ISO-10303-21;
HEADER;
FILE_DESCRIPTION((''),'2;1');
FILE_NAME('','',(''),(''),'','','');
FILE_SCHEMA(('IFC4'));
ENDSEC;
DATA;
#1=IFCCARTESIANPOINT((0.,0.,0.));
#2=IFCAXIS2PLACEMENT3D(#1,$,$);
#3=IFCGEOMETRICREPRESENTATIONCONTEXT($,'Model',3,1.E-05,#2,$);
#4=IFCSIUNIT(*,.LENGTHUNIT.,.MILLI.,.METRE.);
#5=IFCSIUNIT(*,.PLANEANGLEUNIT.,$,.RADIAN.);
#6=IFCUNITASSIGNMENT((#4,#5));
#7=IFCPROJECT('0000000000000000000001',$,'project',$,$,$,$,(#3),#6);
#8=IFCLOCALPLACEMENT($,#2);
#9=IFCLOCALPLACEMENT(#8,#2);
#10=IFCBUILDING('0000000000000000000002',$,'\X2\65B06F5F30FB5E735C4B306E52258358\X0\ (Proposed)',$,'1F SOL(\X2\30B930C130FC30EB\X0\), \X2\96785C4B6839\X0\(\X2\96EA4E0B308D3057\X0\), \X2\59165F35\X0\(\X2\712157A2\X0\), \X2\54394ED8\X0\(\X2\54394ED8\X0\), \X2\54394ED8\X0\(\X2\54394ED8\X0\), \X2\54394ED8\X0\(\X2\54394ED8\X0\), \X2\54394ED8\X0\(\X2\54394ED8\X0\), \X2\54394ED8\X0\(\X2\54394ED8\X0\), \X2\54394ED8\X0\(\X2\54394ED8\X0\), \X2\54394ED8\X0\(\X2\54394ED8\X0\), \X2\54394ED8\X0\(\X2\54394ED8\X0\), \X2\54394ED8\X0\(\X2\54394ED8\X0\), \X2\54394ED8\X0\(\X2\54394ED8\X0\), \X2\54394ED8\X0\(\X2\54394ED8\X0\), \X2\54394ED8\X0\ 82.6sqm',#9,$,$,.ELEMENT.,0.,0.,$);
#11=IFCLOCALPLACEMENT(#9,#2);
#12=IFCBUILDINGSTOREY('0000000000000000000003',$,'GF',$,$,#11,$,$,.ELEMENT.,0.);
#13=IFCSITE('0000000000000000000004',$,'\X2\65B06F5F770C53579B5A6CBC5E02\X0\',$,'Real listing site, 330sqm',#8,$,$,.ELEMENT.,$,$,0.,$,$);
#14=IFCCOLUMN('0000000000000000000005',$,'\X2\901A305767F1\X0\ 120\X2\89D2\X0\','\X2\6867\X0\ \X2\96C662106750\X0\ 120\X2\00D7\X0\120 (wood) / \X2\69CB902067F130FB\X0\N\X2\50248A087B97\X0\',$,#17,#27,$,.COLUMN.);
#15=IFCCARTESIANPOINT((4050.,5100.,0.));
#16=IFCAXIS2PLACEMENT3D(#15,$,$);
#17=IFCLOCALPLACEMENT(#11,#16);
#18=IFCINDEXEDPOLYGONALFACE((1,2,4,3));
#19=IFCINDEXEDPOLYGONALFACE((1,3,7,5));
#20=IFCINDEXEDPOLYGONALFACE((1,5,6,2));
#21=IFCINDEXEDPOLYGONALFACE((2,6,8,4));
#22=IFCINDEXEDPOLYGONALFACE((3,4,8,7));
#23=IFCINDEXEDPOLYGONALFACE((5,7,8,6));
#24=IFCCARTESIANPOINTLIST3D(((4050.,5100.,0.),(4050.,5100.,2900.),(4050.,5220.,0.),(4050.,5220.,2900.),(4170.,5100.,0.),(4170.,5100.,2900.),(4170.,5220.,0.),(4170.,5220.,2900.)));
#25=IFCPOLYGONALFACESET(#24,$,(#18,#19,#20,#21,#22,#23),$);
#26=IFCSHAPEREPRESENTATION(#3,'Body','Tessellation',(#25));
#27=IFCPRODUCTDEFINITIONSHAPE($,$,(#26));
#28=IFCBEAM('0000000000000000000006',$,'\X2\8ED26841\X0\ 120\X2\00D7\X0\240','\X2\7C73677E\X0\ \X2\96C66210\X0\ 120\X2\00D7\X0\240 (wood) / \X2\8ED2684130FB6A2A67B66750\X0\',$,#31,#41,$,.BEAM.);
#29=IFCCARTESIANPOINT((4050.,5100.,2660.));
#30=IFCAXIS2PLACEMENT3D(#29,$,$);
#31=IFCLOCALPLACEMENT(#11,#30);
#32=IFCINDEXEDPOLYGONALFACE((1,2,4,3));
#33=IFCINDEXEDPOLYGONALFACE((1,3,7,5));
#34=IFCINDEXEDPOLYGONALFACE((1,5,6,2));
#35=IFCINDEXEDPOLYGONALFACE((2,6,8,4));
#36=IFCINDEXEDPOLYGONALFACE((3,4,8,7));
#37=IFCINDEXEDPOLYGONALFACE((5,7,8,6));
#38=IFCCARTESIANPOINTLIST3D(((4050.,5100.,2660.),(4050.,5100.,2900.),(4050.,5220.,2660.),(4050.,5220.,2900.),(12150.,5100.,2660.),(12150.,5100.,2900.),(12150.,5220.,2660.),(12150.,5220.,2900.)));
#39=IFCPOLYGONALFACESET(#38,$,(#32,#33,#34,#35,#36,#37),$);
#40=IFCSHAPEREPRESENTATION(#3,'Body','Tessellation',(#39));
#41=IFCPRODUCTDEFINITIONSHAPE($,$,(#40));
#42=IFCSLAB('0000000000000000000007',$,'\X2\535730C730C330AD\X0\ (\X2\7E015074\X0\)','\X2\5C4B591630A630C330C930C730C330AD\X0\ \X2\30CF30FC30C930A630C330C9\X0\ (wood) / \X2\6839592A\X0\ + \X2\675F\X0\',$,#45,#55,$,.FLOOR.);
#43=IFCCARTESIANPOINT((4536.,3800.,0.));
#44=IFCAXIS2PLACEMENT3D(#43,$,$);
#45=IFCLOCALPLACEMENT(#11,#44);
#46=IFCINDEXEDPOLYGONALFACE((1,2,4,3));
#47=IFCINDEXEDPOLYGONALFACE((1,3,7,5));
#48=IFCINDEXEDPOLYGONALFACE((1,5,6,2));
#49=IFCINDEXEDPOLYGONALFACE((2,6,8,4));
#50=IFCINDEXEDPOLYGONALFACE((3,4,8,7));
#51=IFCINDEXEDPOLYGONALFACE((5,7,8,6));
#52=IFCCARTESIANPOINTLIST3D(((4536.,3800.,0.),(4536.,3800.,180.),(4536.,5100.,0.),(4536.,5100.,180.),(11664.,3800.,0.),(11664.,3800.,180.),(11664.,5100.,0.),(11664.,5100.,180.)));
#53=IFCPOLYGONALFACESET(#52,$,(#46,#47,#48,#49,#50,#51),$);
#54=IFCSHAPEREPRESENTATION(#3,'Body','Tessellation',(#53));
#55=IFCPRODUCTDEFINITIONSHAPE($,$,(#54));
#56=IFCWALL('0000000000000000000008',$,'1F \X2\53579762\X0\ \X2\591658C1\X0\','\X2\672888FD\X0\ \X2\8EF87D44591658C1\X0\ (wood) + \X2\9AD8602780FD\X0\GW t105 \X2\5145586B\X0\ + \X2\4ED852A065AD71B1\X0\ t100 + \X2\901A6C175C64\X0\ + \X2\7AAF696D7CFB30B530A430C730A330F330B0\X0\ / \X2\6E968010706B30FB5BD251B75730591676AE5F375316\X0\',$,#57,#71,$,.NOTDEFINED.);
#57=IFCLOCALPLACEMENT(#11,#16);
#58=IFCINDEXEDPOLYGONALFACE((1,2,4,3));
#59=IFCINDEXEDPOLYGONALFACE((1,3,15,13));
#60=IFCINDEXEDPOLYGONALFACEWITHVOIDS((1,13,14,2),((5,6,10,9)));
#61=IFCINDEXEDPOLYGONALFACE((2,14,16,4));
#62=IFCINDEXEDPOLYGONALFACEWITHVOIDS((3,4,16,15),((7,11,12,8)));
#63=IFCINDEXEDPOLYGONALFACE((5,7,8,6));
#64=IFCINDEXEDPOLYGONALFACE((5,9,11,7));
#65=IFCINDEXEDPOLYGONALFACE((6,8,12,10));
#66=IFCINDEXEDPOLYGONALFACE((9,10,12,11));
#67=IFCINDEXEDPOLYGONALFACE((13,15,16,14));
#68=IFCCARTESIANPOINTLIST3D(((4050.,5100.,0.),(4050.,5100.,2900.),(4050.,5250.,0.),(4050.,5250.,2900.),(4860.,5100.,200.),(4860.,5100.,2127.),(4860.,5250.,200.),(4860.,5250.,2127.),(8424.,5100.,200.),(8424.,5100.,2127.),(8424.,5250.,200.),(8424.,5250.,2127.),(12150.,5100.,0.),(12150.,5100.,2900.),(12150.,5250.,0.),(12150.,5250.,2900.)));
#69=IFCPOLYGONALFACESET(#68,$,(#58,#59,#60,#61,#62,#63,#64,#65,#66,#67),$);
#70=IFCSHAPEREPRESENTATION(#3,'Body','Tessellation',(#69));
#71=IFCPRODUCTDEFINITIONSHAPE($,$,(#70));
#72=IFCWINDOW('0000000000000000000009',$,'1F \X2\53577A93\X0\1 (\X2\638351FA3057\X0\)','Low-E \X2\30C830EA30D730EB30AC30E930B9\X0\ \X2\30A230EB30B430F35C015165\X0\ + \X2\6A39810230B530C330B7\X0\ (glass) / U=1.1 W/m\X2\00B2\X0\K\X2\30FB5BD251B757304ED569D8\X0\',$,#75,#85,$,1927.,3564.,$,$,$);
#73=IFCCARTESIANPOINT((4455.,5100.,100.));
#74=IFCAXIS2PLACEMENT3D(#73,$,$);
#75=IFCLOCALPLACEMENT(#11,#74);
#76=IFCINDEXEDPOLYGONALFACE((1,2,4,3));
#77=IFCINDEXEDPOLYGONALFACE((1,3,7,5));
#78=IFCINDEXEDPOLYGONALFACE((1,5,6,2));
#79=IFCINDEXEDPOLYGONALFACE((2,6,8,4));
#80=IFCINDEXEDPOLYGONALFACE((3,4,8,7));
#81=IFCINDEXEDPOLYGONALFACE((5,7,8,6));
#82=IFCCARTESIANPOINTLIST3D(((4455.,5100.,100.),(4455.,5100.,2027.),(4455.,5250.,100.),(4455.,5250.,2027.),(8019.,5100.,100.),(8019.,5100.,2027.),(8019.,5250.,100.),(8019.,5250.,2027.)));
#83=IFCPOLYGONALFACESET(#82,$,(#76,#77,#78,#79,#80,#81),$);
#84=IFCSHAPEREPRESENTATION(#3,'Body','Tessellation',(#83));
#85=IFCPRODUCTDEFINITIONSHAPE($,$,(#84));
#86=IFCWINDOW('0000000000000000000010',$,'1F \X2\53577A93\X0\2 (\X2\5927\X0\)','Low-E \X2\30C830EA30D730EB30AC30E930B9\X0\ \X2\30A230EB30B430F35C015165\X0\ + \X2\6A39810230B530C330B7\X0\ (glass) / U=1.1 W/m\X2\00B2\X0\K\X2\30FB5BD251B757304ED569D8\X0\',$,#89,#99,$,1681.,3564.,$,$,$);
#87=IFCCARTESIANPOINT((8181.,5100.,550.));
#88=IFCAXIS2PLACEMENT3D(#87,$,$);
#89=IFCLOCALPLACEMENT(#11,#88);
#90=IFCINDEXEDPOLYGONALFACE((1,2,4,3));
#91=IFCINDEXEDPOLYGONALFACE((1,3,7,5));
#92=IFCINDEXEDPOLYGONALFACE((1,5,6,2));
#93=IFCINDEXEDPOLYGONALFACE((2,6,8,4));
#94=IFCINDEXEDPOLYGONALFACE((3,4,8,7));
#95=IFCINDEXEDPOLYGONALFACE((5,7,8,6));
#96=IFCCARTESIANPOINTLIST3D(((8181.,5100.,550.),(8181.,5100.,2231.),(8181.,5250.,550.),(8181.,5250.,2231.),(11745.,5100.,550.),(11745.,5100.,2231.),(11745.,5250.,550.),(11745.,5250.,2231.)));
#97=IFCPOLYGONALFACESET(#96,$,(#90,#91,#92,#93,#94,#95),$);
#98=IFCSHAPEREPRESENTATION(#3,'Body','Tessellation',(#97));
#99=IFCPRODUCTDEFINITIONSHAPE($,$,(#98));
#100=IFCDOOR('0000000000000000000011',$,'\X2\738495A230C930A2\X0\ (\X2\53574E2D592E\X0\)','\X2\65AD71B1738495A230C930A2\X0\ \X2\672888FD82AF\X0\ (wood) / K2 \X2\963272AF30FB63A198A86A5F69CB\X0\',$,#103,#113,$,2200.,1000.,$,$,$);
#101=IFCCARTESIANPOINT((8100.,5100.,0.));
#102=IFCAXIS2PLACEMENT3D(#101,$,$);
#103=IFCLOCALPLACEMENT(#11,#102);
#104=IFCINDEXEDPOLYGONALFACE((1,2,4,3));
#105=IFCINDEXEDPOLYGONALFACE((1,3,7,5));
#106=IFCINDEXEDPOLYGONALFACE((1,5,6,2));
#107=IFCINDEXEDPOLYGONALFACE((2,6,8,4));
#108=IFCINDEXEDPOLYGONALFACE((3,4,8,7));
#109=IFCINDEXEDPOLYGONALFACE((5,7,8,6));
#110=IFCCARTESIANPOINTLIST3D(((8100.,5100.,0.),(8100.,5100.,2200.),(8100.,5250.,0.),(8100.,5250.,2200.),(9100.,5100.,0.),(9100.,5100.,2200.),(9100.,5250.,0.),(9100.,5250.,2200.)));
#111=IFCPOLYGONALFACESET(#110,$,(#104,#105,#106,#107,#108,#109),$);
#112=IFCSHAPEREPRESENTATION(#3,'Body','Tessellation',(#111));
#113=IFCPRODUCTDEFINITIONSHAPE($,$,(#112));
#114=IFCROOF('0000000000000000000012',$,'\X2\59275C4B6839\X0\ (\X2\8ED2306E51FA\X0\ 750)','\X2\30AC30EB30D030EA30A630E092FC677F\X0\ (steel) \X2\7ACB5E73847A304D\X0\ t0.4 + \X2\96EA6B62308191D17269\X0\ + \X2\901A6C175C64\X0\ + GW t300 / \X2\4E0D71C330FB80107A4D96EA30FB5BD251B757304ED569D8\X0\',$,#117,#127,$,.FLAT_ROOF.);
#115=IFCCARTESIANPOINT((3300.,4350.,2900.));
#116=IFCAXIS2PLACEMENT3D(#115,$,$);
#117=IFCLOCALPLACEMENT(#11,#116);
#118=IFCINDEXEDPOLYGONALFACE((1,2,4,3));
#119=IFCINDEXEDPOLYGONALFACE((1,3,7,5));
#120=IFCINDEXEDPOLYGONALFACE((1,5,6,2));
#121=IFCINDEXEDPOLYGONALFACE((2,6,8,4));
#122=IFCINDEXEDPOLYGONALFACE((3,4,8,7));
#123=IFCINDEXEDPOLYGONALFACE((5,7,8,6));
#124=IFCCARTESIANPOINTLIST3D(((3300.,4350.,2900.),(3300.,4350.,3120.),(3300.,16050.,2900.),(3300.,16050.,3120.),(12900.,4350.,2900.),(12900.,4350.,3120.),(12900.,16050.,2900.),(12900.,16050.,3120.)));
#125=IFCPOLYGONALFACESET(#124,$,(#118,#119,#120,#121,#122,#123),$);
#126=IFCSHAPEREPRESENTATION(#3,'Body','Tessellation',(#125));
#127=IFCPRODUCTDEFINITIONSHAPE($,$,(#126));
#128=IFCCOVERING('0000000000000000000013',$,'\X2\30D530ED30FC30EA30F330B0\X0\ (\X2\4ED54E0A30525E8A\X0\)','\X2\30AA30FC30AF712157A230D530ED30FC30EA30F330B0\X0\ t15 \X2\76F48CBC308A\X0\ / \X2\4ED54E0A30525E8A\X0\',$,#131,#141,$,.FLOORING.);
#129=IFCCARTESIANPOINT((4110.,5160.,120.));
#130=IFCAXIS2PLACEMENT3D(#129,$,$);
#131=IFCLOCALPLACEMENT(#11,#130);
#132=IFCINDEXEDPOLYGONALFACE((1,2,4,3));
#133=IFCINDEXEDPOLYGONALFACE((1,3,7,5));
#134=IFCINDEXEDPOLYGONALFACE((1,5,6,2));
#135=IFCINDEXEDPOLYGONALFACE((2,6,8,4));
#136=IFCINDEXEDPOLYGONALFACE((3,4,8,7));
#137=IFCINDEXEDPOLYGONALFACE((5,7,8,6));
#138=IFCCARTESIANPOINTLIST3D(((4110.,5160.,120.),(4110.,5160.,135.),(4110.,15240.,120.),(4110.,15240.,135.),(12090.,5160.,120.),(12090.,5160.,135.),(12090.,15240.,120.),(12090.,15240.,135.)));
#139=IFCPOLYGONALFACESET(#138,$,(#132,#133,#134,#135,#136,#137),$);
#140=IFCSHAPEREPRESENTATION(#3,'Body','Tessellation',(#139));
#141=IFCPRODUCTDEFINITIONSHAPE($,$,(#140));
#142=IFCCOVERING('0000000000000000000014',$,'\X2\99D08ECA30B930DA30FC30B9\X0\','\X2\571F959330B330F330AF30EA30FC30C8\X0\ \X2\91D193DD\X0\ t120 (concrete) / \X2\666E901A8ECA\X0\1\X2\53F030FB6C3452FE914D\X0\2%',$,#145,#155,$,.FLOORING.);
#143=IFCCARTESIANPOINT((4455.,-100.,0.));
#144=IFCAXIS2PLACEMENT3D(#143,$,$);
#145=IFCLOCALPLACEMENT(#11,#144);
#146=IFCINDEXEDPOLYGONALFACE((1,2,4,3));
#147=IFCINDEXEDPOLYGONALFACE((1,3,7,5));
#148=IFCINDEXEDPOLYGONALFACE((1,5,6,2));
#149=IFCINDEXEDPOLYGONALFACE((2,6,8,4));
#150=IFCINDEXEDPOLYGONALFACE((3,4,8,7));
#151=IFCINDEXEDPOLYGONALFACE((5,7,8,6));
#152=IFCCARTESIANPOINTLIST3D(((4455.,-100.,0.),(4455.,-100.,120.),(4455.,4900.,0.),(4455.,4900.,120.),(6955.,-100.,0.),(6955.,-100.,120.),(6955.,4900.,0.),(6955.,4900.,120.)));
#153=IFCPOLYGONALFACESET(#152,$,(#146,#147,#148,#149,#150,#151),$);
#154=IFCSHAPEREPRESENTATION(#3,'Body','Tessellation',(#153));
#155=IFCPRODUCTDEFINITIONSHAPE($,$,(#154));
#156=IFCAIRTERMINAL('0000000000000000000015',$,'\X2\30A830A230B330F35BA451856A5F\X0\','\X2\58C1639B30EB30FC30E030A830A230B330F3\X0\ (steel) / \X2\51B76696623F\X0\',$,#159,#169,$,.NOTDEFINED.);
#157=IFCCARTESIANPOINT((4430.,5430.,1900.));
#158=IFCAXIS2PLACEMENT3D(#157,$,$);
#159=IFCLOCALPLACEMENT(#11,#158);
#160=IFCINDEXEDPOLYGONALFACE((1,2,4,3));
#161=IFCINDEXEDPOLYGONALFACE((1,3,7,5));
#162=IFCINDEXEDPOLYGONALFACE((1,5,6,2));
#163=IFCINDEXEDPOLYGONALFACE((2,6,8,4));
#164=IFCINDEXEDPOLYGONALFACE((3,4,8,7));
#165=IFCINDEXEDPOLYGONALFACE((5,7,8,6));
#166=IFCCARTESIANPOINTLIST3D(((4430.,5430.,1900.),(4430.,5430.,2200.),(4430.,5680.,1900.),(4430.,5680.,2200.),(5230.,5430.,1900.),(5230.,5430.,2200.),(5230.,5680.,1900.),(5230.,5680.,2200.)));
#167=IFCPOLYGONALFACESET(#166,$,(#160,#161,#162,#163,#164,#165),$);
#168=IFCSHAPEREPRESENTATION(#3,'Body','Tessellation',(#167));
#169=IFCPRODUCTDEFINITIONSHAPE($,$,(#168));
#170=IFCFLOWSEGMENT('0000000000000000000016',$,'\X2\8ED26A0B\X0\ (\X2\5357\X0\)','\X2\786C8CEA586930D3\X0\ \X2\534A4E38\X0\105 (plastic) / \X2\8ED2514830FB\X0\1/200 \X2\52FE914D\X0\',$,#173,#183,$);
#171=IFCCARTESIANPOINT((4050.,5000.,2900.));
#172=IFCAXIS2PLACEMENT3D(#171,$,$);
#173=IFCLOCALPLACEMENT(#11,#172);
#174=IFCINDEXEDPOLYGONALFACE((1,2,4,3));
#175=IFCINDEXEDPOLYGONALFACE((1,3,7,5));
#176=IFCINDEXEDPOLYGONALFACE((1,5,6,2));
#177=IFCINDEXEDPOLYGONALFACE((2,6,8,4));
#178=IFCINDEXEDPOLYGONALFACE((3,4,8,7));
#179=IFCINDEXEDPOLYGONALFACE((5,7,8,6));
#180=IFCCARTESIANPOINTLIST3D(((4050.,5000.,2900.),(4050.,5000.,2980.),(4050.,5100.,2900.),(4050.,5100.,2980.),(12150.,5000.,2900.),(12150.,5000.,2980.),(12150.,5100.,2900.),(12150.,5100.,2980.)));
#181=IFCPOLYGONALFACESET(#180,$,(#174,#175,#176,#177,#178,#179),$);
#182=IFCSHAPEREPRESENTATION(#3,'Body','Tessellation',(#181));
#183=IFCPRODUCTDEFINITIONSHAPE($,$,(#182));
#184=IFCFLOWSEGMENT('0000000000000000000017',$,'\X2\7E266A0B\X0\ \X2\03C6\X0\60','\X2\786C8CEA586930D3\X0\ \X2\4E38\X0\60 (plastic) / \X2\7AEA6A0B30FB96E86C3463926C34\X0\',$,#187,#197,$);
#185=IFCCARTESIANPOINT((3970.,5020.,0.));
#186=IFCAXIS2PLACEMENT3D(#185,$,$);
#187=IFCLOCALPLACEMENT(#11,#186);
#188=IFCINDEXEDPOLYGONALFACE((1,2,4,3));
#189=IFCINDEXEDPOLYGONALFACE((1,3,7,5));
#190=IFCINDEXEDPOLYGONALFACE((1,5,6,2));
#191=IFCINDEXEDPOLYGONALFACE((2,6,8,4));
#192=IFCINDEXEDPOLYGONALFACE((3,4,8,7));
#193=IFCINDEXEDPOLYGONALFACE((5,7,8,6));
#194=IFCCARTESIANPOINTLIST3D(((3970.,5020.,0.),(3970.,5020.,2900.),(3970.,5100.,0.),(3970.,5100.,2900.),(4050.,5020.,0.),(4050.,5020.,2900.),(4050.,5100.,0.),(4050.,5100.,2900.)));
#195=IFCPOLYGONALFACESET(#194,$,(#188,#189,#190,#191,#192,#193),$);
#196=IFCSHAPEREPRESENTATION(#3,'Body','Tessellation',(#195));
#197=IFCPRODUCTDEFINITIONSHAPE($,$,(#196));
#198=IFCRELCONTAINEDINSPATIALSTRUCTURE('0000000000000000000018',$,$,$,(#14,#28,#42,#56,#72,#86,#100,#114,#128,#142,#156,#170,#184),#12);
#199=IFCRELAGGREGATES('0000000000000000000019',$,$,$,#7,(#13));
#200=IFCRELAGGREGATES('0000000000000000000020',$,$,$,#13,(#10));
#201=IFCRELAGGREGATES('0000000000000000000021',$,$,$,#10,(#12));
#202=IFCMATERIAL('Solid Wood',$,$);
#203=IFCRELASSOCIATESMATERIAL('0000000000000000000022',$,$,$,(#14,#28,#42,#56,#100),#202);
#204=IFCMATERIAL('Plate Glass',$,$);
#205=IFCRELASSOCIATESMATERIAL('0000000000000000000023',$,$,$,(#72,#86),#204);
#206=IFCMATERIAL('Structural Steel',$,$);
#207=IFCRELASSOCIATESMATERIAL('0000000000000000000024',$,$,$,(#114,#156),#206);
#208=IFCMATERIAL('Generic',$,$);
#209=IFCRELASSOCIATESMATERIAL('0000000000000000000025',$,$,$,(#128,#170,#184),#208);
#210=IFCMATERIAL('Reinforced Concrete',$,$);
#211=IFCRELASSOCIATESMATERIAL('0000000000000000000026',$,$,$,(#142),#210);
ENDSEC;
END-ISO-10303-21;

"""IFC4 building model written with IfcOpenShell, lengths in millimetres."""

from ifc_helpers import new_model, si_unit, frame, frame_2d, origin, place, context, project, spatial, rectangle, extrude, material, element, fill, save


model = new_model("IFC4")

# Units and contexts
model_context = context("Model", 3, precision=1e-05, world=origin())
ifc_project = project(units=[si_unit("LENGTHUNIT", "METRE", prefix="MILLI"), si_unit("PLANEANGLEUNIT", "RADIAN")], contexts=[model_context])

# Site, building, storey
site_placement = place(None, origin())
site = spatial("IfcSite", under=ifc_project, at=site_placement, Name="新潟県南魚沼市", ObjectType="Real listing site, 330sqm", CompositionType="ELEMENT", RefElevation=0.0)
building_placement = place(site_placement, origin())
building = spatial("IfcBuilding", under=site, at=building_placement, Name="新潟・平屋の別荘 (Proposed)", ObjectType="1F SOL(スチール), 陸屋根(雪下ろし), 外張(無垢), 吹付(吹付), 吹付(吹付), 吹付(吹付), 吹付(吹付), 吹付(吹付), 吹付(吹付), 吹付(吹付), 吹付(吹付), 吹付(吹付), 吹付(吹付), 吹付(吹付), 吹付 82.6sqm", CompositionType="ELEMENT", ElevationOfRefHeight=0.0, ElevationOfTerrain=0.0)
storey_placement = place(building_placement, origin())
storey = spatial("IfcBuildingStorey", under=building, at=storey_placement, Name="GF", CompositionType="ELEMENT", Elevation=0.0)

# Column
ifc_material_1 = material(Name="Solid Wood")
column_1_placement = place(storey_placement, frame((4050.0, 5100.0, 0.0)))
element("IfcColumn", 1, at=column_1_placement, inside=storey, material=ifc_material_1, Name="通し柱 120角", Description="桧 集成材 120×120 (wood) / 構造柱・N値計算", PredefinedType="COLUMN", context=model_context, shape_type="SweptSolid", body=[
    extrude(rectangle(XDim=120.0, YDim=120.0, at=frame_2d((60.0, 60.0))), frame((4050.0, 5100.0, 0.0)), (0.0, 0.0, 1.0), 2900.0),
])

# Beam
beam_1_placement = place(storey_placement, frame((4050.0, 5100.0, 2660.0)))
element("IfcBeam", 2, at=beam_1_placement, inside=storey, material=ifc_material_1, Name="軒桁 120×240", Description="米松 集成 120×240 (wood) / 軒桁・横架材", PredefinedType="BEAM", context=model_context, shape_type="SweptSolid", body=[
    extrude(rectangle(XDim=8100.0, YDim=120.0, at=frame_2d((4050.0, 60.0))), frame((4050.0, 5100.0, 2660.0)), (0.0, 0.0, 1.0), 240.0),
])

# Slab
ifc_material_2 = material(Name="Reinforced Concrete")
slab_1_placement = place(storey_placement, frame((4536.0, 3800.0, 0.0)))
element("IfcSlab", 3, at=slab_1_placement, inside=storey, material=ifc_material_1, Name="南デッキ (縁側)", Description="屋外ウッドデッキ ハードウッド (wood) / 根太 + 束", PredefinedType="FLOOR", context=model_context, shape_type="SweptSolid", body=[
    extrude(rectangle(XDim=7128.0, YDim=1300.0, at=frame_2d((3564.0, 650.0))), frame((4536.0, 3800.0, 0.0)), (0.0, 0.0, 1.0), 180.0),
])

# Wall, openings, windows, door
wall_1_placement = place(storey_placement, frame((4050.0, 5100.0, 0.0)))
wall_1 = element("IfcWall", 4, at=wall_1_placement, inside=storey, material=ifc_material_1, Name="1F 南面 外壁", Description="木製 軸組外壁 (wood) + 高性能GW t105 充填 + 付加断熱 t100 + 通気層 + 窯業系サイディング / 準耐火・寒冷地外皮強化", PredefinedType="NOTDEFINED", context=model_context, shape_type="SweptSolid", body=[
    extrude(rectangle(XDim=8100.0, YDim=150.0, at=frame_2d((4050.0, 75.0))), frame((4050.0, 5100.0, 0.0)), (0.0, 0.0, 1.0), 2900.0),
])
opening_1_placement = place(storey_placement, frame((4455.0, 5100.0, 100.0)))
opening_1 = element("IfcOpeningElement", 5, at=opening_1_placement, cuts=wall_1, PredefinedType="NOTDEFINED", context=model_context, shape_type="SweptSolid", body=[
    extrude(rectangle(XDim=3564.0, YDim=150.0, at=frame_2d((1782.0, 75.0))), frame((4455.0, 5100.0, 100.0)), (0.0, 0.0, 1.0), 1927.0),
])
opening_2_placement = place(storey_placement, frame((8181.0, 5100.0, 550.0)))
opening_2 = element("IfcOpeningElement", 6, at=opening_2_placement, cuts=wall_1, PredefinedType="NOTDEFINED", context=model_context, shape_type="SweptSolid", body=[
    extrude(rectangle(XDim=3564.0, YDim=150.0, at=frame_2d((1782.0, 75.0))), frame((8181.0, 5100.0, 550.0)), (0.0, 0.0, 1.0), 1681.0),
])
opening_3_placement = place(storey_placement, frame((8100.0, 5100.0, 0.0)))
opening_3 = element("IfcOpeningElement", 7, at=opening_3_placement, cuts=wall_1, PredefinedType="NOTDEFINED", context=model_context, shape_type="SweptSolid", body=[
    extrude(rectangle(XDim=1000.0, YDim=150.0, at=frame_2d((500.0, 75.0))), frame((8100.0, 5100.0, 0.0)), (0.0, 0.0, 1.0), 2200.0),
])
ifc_material_3 = material(Name="Plate Glass")
window_1_placement = place(storey_placement, frame((4455.0, 5100.0, 100.0)))
window_1 = element("IfcWindow", 8, at=window_1_placement, inside=storey, material=ifc_material_3, Name="1F 南窓1 (掃出し)", Description="Low-E トリプルガラス アルゴン封入 + 樹脂サッシ (glass) / U=1.1 W/m²K・寒冷地仕様", OverallHeight=1927.0, OverallWidth=3564.0, context=model_context, shape_type="SweptSolid", body=[
    extrude(rectangle(XDim=3564.0, YDim=150.0, at=frame_2d((1782.0, 75.0))), frame((4455.0, 5100.0, 100.0)), (0.0, 0.0, 1.0), 1927.0),
])
fill(opening_1, window_1)
window_2_placement = place(storey_placement, frame((8181.0, 5100.0, 550.0)))
window_2 = element("IfcWindow", 9, at=window_2_placement, inside=storey, material=ifc_material_3, Name="1F 南窓2 (大)", Description="Low-E トリプルガラス アルゴン封入 + 樹脂サッシ (glass) / U=1.1 W/m²K・寒冷地仕様", OverallHeight=1681.0, OverallWidth=3564.0, context=model_context, shape_type="SweptSolid", body=[
    extrude(rectangle(XDim=3564.0, YDim=150.0, at=frame_2d((1782.0, 75.0))), frame((8181.0, 5100.0, 550.0)), (0.0, 0.0, 1.0), 1681.0),
])
fill(opening_2, window_2)
door_placement = place(storey_placement, frame((8100.0, 5100.0, 0.0)))
door = element("IfcDoor", 10, at=door_placement, inside=storey, material=ifc_material_1, Name="玄関ドア (南中央)", Description="断熱玄関ドア 木製芯 (wood) / K2 防犯・採風機構", OverallHeight=2200.0, OverallWidth=1000.0, context=model_context, shape_type="SweptSolid", body=[
    extrude(rectangle(XDim=1000.0, YDim=150.0, at=frame_2d((500.0, 75.0))), frame((8100.0, 5100.0, 0.0)), (0.0, 0.0, 1.0), 2200.0),
])
fill(opening_3, door)

# Roof
ifc_material_4 = material(Name="Structural Steel")
roof_placement = place(storey_placement, frame((3300.0, 4350.0, 2900.0)))
element("IfcRoof", 11, at=roof_placement, inside=storey, material=ifc_material_4, Name="大屋根 (軒の出 750)", Description="ガルバリウム鋼板 (steel) 立平葺き t0.4 + 雪止め金物 + 通気層 + GW t300 / 不燃・耐積雪・寒冷地仕様", PredefinedType="FLAT_ROOF", context=model_context, shape_type="SweptSolid", body=[
    extrude(rectangle(XDim=9600.0, YDim=11700.0, at=frame_2d((4800.0, 5850.0))), frame((3300.0, 4350.0, 2900.0)), (0.0, 0.0, 1.0), 220.0),
])

# Coverings
ifc_material_5 = material(Name="Generic")
covering_1_placement = place(storey_placement, frame((4110.0, 5160.0, 120.0)))
element("IfcCovering", 12, at=covering_1_placement, inside=storey, material=ifc_material_5, Name="フローリング (仕上げ床)", Description="オーク無垢フローリング t15 直貼り / 仕上げ床", PredefinedType="FLOORING", context=model_context, shape_type="SweptSolid", body=[
    extrude(rectangle(XDim=7980.0, YDim=10080.0, at=frame_2d((3990.0, 5040.0))), frame((4110.0, 5160.0, 120.0)), (0.0, 0.0, 1.0), 15.0),
])
covering_2_placement = place(storey_placement, frame((4455.0, -100.0, 0.0)))
element("IfcCovering", 13, at=covering_2_placement, inside=storey, material=ifc_material_2, Name="駐車スペース", Description="土間コンクリート 金鏝 t120 (concrete) / 普通車1台・水勾配2%", PredefinedType="FLOORING", context=model_context, shape_type="SweptSolid", body=[
    extrude(rectangle(XDim=2500.0, YDim=5000.0, at=frame_2d((1250.0, 2500.0))), frame((4455.0, -100.0, 0.0)), (0.0, 0.0, 1.0), 120.0),
])

# Air terminal
air_terminal_placement = place(storey_placement, frame((4430.0, 5430.0, 1900.0)))
element("IfcAirTerminal", 14, at=air_terminal_placement, inside=storey, material=ifc_material_4, Name="エアコン室内機", Description="壁掛ルームエアコン (steel) / 冷暖房", PredefinedType="NOTDEFINED", context=model_context, shape_type="SweptSolid", body=[
    extrude(rectangle(XDim=800.0, YDim=250.0, at=frame_2d((400.0, 125.0))), frame((4430.0, 5430.0, 1900.0)), (0.0, 0.0, 1.0), 300.0),
])

# Flow segments
flow_segment_1_placement = place(storey_placement, frame((4050.0, 5000.0, 2900.0)))
element("IfcFlowSegment", 15, at=flow_segment_1_placement, inside=storey, material=ifc_material_5, Name="軒樋 (南)", Description="硬質塩ビ 半丸105 (plastic) / 軒先・1/200 勾配", context=model_context, shape_type="SweptSolid", body=[
    extrude(rectangle(XDim=8100.0, YDim=100.0, at=frame_2d((4050.0, 50.0))), frame((4050.0, 5000.0, 2900.0)), (0.0, 0.0, 1.0), 80.0),
])
flow_segment_2_placement = place(storey_placement, frame((3970.0, 5020.0, 0.0)))
element("IfcFlowSegment", 16, at=flow_segment_2_placement, inside=storey, material=ifc_material_5, Name="縦樋 φ60", Description="硬質塩ビ 丸60 (plastic) / 竪樋・雨水排水", context=model_context, shape_type="SweptSolid", body=[
    extrude(rectangle(XDim=80.0, YDim=80.0, at=frame_2d((40.0, 40.0))), frame((3970.0, 5020.0, 0.0)), (0.0, 0.0, 1.0), 2900.0),
])

save(model, "model.ifc")
